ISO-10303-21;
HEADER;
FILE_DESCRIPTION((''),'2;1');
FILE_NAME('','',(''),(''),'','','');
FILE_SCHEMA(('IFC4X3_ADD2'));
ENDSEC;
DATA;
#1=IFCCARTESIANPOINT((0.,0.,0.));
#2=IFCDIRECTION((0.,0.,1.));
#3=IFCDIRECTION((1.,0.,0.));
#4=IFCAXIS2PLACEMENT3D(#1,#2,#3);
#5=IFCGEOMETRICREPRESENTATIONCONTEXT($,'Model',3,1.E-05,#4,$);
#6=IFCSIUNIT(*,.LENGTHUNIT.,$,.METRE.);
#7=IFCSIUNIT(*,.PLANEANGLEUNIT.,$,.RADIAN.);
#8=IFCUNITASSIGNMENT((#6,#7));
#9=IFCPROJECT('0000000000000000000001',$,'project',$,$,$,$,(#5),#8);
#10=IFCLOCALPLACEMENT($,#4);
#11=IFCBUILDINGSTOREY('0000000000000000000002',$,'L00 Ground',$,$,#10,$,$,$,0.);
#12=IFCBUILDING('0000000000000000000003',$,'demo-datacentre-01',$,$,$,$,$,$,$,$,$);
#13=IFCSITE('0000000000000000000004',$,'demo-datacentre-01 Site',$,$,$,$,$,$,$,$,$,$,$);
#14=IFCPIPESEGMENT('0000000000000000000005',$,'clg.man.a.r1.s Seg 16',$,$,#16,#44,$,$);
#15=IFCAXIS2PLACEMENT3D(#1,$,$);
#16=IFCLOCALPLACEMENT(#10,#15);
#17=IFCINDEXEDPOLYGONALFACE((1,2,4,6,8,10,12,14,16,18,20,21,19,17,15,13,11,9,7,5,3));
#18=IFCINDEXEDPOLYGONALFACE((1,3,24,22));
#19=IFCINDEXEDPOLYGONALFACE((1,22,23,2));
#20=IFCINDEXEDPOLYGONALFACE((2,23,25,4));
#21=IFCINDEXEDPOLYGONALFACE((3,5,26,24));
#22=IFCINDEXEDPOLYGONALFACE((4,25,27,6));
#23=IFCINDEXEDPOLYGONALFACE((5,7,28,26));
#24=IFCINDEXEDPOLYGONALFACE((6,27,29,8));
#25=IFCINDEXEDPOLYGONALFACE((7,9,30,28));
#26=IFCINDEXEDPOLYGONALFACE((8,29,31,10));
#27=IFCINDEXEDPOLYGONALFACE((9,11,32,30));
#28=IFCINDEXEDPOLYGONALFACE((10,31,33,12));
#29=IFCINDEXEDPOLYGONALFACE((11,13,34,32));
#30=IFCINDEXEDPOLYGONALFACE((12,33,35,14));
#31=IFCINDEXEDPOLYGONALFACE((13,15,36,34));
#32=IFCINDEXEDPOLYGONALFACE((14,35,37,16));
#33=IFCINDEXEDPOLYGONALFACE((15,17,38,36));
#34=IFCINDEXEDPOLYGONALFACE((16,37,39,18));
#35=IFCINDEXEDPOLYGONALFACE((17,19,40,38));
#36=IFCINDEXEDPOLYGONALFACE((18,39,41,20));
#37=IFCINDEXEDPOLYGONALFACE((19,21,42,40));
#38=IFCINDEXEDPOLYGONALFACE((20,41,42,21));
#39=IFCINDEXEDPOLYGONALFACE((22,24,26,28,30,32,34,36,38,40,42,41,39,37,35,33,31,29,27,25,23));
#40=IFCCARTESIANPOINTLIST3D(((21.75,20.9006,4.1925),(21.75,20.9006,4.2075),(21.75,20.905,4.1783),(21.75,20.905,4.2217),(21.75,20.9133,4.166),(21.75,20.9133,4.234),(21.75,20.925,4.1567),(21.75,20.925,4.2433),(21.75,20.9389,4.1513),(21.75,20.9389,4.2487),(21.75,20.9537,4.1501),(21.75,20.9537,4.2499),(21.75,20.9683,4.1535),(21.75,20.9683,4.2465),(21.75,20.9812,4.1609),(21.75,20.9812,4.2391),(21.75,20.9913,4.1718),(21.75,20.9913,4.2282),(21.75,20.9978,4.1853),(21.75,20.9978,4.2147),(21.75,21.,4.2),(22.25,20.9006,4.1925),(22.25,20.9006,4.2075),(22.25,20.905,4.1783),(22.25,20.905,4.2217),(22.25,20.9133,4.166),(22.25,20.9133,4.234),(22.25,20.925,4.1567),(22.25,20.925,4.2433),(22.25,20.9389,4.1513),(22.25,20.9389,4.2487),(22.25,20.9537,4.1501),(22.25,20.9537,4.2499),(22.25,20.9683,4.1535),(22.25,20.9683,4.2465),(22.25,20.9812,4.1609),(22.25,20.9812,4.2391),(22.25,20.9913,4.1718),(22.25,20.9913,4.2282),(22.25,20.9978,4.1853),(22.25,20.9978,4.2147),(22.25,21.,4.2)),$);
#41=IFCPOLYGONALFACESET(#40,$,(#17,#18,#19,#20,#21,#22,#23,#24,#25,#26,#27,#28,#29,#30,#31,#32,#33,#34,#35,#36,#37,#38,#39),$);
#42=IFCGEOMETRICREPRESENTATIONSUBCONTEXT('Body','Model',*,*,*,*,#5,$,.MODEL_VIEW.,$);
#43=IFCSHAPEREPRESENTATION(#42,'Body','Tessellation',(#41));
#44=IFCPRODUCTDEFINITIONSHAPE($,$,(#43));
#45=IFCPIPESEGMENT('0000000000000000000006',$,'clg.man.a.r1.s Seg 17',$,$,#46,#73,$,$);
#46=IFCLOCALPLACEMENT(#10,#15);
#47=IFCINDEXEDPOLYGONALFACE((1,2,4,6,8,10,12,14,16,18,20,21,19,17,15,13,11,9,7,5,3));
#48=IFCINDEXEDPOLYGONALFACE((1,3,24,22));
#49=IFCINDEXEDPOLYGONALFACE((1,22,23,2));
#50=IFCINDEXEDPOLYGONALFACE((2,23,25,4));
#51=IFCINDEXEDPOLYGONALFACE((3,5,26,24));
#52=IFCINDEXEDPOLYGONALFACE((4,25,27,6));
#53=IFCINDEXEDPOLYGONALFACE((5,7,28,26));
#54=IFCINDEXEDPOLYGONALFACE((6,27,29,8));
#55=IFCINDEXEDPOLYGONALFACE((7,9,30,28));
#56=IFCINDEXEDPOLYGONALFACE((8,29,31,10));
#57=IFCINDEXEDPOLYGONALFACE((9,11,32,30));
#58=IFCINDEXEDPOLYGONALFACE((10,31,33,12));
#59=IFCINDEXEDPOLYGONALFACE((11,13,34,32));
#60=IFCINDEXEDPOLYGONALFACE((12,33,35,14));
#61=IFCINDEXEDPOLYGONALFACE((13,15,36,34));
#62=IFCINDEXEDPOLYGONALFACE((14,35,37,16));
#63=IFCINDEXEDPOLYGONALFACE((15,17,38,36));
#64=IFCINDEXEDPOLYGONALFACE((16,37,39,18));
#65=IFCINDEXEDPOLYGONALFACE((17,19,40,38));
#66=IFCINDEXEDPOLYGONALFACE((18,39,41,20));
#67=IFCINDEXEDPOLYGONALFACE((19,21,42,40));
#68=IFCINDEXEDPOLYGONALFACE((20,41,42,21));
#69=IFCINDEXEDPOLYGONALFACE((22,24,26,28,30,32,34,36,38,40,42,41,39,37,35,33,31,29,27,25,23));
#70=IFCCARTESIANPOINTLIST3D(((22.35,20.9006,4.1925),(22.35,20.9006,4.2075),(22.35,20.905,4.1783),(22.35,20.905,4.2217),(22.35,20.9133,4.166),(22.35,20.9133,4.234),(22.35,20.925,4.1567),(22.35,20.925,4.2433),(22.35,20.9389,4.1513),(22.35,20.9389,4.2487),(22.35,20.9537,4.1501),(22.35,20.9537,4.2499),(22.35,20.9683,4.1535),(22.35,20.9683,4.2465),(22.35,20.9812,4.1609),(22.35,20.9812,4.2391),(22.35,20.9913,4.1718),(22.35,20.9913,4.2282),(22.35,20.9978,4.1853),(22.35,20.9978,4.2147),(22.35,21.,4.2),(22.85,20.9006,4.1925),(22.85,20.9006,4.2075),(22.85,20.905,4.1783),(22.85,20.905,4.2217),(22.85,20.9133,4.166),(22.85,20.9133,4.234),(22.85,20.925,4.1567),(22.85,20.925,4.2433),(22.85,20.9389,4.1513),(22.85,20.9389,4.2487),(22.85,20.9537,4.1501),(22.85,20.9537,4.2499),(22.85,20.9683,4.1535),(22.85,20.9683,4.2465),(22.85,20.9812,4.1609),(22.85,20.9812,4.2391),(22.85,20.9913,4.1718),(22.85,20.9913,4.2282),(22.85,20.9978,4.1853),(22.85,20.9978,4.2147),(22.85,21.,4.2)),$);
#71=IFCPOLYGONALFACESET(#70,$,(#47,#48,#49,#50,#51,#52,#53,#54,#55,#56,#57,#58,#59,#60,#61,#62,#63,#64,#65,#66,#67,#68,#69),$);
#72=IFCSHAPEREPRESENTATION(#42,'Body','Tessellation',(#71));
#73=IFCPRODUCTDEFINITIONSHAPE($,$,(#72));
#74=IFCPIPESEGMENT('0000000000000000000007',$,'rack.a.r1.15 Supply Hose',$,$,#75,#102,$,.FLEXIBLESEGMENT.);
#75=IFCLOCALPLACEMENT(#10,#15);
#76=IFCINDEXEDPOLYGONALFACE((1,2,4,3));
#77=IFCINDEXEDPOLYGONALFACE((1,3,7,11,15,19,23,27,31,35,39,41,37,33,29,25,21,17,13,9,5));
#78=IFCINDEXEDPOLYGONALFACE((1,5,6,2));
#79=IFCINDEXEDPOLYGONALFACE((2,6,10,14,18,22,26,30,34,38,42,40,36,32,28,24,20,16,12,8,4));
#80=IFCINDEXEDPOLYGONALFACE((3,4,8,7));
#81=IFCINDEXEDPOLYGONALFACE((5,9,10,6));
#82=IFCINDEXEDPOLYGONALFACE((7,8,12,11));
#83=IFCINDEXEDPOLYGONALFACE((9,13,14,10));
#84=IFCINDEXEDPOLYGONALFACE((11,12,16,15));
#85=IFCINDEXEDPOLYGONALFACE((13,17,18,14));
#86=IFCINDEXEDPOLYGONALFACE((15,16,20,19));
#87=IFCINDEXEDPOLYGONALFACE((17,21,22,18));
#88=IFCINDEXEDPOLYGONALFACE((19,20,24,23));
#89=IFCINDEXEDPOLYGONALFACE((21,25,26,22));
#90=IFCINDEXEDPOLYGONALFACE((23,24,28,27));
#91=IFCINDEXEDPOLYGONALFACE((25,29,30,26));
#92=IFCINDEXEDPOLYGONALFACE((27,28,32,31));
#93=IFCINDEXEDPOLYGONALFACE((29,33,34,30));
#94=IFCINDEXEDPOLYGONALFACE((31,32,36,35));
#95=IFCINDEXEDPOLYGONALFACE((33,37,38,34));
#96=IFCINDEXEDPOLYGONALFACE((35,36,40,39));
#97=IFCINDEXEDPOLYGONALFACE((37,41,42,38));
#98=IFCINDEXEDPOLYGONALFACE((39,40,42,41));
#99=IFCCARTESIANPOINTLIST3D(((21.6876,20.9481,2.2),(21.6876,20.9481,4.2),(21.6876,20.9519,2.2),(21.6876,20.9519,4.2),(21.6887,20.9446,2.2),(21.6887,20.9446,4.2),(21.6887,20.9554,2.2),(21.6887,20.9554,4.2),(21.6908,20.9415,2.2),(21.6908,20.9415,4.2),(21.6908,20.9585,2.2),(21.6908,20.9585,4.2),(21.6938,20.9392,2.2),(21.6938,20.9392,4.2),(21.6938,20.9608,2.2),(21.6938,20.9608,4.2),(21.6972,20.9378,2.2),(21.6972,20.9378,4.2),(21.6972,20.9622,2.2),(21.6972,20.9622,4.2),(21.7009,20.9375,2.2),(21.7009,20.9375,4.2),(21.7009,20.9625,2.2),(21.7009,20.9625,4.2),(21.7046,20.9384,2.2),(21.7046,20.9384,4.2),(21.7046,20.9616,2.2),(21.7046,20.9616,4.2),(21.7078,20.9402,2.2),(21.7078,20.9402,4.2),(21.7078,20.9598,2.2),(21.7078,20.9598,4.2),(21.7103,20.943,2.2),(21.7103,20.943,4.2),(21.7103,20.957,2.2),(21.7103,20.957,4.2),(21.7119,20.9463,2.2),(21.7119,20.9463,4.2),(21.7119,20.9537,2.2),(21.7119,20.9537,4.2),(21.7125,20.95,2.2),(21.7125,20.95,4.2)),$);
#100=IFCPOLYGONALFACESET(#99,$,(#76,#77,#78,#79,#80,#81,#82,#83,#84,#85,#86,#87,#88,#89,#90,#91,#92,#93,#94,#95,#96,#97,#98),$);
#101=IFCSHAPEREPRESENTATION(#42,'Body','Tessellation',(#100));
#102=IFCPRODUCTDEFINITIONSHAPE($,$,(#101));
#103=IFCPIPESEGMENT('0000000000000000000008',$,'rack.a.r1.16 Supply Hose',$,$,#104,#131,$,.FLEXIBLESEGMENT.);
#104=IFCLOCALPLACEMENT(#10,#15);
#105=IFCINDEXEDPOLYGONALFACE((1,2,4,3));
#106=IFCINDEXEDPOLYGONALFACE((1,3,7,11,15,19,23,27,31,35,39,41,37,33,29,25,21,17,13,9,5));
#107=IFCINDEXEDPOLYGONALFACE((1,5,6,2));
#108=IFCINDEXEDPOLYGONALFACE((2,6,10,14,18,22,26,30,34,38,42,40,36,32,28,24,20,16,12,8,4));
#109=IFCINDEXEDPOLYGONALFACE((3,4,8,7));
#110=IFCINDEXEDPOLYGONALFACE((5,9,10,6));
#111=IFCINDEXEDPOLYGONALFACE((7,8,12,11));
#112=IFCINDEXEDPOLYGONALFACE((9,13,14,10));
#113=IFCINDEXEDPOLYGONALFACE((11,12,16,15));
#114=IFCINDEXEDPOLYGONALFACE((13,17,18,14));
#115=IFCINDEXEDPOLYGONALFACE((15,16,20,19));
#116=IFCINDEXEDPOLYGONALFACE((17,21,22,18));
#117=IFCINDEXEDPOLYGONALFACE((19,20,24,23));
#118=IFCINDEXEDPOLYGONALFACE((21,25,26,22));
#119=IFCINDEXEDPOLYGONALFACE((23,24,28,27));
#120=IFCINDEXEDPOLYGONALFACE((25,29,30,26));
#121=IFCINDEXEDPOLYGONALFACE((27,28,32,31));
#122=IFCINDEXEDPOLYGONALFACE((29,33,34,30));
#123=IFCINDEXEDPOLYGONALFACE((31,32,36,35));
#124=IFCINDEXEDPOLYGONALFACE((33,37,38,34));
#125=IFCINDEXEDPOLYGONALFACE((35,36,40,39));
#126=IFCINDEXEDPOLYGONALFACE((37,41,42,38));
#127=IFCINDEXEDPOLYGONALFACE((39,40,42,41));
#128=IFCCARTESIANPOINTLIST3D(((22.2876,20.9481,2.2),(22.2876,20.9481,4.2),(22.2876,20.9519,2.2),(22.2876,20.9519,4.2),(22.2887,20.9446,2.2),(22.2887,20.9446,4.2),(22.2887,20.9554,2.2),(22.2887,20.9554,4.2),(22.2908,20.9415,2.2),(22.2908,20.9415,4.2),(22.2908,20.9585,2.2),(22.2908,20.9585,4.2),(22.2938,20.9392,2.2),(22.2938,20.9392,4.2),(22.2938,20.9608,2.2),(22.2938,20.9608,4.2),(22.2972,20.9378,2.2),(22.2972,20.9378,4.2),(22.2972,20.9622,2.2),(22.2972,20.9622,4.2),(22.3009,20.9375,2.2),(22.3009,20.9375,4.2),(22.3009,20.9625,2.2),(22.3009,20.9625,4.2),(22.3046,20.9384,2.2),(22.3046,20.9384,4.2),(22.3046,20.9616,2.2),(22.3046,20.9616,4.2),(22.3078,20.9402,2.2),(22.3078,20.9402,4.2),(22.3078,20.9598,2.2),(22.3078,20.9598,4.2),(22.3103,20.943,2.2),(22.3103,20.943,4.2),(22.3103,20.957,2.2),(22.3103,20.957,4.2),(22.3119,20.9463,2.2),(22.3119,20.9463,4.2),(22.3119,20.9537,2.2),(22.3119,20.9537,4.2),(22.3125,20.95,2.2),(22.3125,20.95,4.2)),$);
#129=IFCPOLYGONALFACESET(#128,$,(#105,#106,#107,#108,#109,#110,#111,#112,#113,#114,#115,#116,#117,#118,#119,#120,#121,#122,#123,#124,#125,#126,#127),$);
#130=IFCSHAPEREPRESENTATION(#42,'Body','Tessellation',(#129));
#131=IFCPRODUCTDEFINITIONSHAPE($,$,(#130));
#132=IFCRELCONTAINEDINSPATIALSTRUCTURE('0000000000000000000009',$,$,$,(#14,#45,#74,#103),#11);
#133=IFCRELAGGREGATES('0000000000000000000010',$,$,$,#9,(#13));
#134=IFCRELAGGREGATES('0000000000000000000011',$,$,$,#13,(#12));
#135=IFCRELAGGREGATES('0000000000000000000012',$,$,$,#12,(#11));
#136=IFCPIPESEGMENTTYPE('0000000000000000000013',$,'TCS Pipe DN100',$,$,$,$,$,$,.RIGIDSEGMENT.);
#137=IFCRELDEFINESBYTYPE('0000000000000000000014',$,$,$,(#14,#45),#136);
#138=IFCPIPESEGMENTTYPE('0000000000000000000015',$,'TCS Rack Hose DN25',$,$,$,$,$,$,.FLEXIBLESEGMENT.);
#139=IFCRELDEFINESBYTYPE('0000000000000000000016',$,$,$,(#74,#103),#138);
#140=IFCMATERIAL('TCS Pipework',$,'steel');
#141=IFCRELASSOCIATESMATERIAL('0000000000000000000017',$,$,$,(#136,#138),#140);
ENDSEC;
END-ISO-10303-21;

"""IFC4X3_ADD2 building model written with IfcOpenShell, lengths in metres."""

from ifc_helpers import new_model, si_unit, frame, origin_with_axes, place, context, subcontext, project, spatial, circle, extrude, material, type_object, element, save


model = new_model("IFC4X3_ADD2")

# Units and contexts
model_context = context("Model", 3, precision=1e-05, world=origin_with_axes())
body_context = subcontext(model_context, "Body", "Model", "MODEL_VIEW")
ifc_project = project(units=[si_unit("LENGTHUNIT", "METRE"), si_unit("PLANEANGLEUNIT", "RADIAN")], contexts=[model_context])

# Site, building, storey
site = spatial("IfcSite", under=ifc_project, Name="demo-datacentre-01 Site")
building = spatial("IfcBuilding", under=site, Name="demo-datacentre-01")
storey_placement = place(None, origin_with_axes())
storey = spatial("IfcBuildingStorey", under=building, at=storey_placement, Name="L00 Ground", Elevation=0.0)

# Shared definitions
ifc_material_1 = material(Name="TCS Pipework", Category="steel")

# Pipe segments
pipe_segment_type_1 = type_object("IfcPipeSegmentType", Name="TCS Pipe DN100", PredefinedType="RIGIDSEGMENT", material=ifc_material_1)
for number, where, z_axis, x_axis, name in (
    (1, (21.75, 20.95, 4.2), (1.0, 0.0, 0.0), (0.0, 1.0, 0.0), "clg.man.a.r1.s Seg 16"),
    (2, (22.35, 20.95, 4.2), (1.0, 0.0, 0.0), (0.0, 1.0, 0.0), "clg.man.a.r1.s Seg 17"),
):
    element("IfcPipeSegment", number, at=place(storey_placement, frame(where, z_axis=z_axis, x_axis=x_axis)), inside=storey, type_object=pipe_segment_type_1, Name=name, context=body_context, shape_type="SweptSolid", body=[
        extrude(circle(Radius=0.05), origin_with_axes(), (0.0, 0.0, 1.0), 0.5),
    ])
pipe_segment_type_2 = type_object("IfcPipeSegmentType", Name="TCS Rack Hose DN25", PredefinedType="FLEXIBLESEGMENT", material=ifc_material_1)
for number, where, z_axis, x_axis, name in (
    (3, (21.7, 20.95, 4.2), (0.0, 0.0, -1.0), (1.0, 0.0, 0.0), "rack.a.r1.15 Supply Hose"),
    (4, (22.3, 20.95, 4.2), (0.0, 0.0, -1.0), (1.0, 0.0, 0.0), "rack.a.r1.16 Supply Hose"),
):
    element("IfcPipeSegment", number, at=place(storey_placement, frame(where, z_axis=z_axis, x_axis=x_axis)), inside=storey, type_object=pipe_segment_type_2, Name=name, PredefinedType="FLEXIBLESEGMENT", context=body_context, shape_type="SweptSolid", body=[
        extrude(circle(Radius=0.0125), origin_with_axes(), (0.0, 0.0, 1.0), 2.0),
    ])

save(model, "model.ifc")
